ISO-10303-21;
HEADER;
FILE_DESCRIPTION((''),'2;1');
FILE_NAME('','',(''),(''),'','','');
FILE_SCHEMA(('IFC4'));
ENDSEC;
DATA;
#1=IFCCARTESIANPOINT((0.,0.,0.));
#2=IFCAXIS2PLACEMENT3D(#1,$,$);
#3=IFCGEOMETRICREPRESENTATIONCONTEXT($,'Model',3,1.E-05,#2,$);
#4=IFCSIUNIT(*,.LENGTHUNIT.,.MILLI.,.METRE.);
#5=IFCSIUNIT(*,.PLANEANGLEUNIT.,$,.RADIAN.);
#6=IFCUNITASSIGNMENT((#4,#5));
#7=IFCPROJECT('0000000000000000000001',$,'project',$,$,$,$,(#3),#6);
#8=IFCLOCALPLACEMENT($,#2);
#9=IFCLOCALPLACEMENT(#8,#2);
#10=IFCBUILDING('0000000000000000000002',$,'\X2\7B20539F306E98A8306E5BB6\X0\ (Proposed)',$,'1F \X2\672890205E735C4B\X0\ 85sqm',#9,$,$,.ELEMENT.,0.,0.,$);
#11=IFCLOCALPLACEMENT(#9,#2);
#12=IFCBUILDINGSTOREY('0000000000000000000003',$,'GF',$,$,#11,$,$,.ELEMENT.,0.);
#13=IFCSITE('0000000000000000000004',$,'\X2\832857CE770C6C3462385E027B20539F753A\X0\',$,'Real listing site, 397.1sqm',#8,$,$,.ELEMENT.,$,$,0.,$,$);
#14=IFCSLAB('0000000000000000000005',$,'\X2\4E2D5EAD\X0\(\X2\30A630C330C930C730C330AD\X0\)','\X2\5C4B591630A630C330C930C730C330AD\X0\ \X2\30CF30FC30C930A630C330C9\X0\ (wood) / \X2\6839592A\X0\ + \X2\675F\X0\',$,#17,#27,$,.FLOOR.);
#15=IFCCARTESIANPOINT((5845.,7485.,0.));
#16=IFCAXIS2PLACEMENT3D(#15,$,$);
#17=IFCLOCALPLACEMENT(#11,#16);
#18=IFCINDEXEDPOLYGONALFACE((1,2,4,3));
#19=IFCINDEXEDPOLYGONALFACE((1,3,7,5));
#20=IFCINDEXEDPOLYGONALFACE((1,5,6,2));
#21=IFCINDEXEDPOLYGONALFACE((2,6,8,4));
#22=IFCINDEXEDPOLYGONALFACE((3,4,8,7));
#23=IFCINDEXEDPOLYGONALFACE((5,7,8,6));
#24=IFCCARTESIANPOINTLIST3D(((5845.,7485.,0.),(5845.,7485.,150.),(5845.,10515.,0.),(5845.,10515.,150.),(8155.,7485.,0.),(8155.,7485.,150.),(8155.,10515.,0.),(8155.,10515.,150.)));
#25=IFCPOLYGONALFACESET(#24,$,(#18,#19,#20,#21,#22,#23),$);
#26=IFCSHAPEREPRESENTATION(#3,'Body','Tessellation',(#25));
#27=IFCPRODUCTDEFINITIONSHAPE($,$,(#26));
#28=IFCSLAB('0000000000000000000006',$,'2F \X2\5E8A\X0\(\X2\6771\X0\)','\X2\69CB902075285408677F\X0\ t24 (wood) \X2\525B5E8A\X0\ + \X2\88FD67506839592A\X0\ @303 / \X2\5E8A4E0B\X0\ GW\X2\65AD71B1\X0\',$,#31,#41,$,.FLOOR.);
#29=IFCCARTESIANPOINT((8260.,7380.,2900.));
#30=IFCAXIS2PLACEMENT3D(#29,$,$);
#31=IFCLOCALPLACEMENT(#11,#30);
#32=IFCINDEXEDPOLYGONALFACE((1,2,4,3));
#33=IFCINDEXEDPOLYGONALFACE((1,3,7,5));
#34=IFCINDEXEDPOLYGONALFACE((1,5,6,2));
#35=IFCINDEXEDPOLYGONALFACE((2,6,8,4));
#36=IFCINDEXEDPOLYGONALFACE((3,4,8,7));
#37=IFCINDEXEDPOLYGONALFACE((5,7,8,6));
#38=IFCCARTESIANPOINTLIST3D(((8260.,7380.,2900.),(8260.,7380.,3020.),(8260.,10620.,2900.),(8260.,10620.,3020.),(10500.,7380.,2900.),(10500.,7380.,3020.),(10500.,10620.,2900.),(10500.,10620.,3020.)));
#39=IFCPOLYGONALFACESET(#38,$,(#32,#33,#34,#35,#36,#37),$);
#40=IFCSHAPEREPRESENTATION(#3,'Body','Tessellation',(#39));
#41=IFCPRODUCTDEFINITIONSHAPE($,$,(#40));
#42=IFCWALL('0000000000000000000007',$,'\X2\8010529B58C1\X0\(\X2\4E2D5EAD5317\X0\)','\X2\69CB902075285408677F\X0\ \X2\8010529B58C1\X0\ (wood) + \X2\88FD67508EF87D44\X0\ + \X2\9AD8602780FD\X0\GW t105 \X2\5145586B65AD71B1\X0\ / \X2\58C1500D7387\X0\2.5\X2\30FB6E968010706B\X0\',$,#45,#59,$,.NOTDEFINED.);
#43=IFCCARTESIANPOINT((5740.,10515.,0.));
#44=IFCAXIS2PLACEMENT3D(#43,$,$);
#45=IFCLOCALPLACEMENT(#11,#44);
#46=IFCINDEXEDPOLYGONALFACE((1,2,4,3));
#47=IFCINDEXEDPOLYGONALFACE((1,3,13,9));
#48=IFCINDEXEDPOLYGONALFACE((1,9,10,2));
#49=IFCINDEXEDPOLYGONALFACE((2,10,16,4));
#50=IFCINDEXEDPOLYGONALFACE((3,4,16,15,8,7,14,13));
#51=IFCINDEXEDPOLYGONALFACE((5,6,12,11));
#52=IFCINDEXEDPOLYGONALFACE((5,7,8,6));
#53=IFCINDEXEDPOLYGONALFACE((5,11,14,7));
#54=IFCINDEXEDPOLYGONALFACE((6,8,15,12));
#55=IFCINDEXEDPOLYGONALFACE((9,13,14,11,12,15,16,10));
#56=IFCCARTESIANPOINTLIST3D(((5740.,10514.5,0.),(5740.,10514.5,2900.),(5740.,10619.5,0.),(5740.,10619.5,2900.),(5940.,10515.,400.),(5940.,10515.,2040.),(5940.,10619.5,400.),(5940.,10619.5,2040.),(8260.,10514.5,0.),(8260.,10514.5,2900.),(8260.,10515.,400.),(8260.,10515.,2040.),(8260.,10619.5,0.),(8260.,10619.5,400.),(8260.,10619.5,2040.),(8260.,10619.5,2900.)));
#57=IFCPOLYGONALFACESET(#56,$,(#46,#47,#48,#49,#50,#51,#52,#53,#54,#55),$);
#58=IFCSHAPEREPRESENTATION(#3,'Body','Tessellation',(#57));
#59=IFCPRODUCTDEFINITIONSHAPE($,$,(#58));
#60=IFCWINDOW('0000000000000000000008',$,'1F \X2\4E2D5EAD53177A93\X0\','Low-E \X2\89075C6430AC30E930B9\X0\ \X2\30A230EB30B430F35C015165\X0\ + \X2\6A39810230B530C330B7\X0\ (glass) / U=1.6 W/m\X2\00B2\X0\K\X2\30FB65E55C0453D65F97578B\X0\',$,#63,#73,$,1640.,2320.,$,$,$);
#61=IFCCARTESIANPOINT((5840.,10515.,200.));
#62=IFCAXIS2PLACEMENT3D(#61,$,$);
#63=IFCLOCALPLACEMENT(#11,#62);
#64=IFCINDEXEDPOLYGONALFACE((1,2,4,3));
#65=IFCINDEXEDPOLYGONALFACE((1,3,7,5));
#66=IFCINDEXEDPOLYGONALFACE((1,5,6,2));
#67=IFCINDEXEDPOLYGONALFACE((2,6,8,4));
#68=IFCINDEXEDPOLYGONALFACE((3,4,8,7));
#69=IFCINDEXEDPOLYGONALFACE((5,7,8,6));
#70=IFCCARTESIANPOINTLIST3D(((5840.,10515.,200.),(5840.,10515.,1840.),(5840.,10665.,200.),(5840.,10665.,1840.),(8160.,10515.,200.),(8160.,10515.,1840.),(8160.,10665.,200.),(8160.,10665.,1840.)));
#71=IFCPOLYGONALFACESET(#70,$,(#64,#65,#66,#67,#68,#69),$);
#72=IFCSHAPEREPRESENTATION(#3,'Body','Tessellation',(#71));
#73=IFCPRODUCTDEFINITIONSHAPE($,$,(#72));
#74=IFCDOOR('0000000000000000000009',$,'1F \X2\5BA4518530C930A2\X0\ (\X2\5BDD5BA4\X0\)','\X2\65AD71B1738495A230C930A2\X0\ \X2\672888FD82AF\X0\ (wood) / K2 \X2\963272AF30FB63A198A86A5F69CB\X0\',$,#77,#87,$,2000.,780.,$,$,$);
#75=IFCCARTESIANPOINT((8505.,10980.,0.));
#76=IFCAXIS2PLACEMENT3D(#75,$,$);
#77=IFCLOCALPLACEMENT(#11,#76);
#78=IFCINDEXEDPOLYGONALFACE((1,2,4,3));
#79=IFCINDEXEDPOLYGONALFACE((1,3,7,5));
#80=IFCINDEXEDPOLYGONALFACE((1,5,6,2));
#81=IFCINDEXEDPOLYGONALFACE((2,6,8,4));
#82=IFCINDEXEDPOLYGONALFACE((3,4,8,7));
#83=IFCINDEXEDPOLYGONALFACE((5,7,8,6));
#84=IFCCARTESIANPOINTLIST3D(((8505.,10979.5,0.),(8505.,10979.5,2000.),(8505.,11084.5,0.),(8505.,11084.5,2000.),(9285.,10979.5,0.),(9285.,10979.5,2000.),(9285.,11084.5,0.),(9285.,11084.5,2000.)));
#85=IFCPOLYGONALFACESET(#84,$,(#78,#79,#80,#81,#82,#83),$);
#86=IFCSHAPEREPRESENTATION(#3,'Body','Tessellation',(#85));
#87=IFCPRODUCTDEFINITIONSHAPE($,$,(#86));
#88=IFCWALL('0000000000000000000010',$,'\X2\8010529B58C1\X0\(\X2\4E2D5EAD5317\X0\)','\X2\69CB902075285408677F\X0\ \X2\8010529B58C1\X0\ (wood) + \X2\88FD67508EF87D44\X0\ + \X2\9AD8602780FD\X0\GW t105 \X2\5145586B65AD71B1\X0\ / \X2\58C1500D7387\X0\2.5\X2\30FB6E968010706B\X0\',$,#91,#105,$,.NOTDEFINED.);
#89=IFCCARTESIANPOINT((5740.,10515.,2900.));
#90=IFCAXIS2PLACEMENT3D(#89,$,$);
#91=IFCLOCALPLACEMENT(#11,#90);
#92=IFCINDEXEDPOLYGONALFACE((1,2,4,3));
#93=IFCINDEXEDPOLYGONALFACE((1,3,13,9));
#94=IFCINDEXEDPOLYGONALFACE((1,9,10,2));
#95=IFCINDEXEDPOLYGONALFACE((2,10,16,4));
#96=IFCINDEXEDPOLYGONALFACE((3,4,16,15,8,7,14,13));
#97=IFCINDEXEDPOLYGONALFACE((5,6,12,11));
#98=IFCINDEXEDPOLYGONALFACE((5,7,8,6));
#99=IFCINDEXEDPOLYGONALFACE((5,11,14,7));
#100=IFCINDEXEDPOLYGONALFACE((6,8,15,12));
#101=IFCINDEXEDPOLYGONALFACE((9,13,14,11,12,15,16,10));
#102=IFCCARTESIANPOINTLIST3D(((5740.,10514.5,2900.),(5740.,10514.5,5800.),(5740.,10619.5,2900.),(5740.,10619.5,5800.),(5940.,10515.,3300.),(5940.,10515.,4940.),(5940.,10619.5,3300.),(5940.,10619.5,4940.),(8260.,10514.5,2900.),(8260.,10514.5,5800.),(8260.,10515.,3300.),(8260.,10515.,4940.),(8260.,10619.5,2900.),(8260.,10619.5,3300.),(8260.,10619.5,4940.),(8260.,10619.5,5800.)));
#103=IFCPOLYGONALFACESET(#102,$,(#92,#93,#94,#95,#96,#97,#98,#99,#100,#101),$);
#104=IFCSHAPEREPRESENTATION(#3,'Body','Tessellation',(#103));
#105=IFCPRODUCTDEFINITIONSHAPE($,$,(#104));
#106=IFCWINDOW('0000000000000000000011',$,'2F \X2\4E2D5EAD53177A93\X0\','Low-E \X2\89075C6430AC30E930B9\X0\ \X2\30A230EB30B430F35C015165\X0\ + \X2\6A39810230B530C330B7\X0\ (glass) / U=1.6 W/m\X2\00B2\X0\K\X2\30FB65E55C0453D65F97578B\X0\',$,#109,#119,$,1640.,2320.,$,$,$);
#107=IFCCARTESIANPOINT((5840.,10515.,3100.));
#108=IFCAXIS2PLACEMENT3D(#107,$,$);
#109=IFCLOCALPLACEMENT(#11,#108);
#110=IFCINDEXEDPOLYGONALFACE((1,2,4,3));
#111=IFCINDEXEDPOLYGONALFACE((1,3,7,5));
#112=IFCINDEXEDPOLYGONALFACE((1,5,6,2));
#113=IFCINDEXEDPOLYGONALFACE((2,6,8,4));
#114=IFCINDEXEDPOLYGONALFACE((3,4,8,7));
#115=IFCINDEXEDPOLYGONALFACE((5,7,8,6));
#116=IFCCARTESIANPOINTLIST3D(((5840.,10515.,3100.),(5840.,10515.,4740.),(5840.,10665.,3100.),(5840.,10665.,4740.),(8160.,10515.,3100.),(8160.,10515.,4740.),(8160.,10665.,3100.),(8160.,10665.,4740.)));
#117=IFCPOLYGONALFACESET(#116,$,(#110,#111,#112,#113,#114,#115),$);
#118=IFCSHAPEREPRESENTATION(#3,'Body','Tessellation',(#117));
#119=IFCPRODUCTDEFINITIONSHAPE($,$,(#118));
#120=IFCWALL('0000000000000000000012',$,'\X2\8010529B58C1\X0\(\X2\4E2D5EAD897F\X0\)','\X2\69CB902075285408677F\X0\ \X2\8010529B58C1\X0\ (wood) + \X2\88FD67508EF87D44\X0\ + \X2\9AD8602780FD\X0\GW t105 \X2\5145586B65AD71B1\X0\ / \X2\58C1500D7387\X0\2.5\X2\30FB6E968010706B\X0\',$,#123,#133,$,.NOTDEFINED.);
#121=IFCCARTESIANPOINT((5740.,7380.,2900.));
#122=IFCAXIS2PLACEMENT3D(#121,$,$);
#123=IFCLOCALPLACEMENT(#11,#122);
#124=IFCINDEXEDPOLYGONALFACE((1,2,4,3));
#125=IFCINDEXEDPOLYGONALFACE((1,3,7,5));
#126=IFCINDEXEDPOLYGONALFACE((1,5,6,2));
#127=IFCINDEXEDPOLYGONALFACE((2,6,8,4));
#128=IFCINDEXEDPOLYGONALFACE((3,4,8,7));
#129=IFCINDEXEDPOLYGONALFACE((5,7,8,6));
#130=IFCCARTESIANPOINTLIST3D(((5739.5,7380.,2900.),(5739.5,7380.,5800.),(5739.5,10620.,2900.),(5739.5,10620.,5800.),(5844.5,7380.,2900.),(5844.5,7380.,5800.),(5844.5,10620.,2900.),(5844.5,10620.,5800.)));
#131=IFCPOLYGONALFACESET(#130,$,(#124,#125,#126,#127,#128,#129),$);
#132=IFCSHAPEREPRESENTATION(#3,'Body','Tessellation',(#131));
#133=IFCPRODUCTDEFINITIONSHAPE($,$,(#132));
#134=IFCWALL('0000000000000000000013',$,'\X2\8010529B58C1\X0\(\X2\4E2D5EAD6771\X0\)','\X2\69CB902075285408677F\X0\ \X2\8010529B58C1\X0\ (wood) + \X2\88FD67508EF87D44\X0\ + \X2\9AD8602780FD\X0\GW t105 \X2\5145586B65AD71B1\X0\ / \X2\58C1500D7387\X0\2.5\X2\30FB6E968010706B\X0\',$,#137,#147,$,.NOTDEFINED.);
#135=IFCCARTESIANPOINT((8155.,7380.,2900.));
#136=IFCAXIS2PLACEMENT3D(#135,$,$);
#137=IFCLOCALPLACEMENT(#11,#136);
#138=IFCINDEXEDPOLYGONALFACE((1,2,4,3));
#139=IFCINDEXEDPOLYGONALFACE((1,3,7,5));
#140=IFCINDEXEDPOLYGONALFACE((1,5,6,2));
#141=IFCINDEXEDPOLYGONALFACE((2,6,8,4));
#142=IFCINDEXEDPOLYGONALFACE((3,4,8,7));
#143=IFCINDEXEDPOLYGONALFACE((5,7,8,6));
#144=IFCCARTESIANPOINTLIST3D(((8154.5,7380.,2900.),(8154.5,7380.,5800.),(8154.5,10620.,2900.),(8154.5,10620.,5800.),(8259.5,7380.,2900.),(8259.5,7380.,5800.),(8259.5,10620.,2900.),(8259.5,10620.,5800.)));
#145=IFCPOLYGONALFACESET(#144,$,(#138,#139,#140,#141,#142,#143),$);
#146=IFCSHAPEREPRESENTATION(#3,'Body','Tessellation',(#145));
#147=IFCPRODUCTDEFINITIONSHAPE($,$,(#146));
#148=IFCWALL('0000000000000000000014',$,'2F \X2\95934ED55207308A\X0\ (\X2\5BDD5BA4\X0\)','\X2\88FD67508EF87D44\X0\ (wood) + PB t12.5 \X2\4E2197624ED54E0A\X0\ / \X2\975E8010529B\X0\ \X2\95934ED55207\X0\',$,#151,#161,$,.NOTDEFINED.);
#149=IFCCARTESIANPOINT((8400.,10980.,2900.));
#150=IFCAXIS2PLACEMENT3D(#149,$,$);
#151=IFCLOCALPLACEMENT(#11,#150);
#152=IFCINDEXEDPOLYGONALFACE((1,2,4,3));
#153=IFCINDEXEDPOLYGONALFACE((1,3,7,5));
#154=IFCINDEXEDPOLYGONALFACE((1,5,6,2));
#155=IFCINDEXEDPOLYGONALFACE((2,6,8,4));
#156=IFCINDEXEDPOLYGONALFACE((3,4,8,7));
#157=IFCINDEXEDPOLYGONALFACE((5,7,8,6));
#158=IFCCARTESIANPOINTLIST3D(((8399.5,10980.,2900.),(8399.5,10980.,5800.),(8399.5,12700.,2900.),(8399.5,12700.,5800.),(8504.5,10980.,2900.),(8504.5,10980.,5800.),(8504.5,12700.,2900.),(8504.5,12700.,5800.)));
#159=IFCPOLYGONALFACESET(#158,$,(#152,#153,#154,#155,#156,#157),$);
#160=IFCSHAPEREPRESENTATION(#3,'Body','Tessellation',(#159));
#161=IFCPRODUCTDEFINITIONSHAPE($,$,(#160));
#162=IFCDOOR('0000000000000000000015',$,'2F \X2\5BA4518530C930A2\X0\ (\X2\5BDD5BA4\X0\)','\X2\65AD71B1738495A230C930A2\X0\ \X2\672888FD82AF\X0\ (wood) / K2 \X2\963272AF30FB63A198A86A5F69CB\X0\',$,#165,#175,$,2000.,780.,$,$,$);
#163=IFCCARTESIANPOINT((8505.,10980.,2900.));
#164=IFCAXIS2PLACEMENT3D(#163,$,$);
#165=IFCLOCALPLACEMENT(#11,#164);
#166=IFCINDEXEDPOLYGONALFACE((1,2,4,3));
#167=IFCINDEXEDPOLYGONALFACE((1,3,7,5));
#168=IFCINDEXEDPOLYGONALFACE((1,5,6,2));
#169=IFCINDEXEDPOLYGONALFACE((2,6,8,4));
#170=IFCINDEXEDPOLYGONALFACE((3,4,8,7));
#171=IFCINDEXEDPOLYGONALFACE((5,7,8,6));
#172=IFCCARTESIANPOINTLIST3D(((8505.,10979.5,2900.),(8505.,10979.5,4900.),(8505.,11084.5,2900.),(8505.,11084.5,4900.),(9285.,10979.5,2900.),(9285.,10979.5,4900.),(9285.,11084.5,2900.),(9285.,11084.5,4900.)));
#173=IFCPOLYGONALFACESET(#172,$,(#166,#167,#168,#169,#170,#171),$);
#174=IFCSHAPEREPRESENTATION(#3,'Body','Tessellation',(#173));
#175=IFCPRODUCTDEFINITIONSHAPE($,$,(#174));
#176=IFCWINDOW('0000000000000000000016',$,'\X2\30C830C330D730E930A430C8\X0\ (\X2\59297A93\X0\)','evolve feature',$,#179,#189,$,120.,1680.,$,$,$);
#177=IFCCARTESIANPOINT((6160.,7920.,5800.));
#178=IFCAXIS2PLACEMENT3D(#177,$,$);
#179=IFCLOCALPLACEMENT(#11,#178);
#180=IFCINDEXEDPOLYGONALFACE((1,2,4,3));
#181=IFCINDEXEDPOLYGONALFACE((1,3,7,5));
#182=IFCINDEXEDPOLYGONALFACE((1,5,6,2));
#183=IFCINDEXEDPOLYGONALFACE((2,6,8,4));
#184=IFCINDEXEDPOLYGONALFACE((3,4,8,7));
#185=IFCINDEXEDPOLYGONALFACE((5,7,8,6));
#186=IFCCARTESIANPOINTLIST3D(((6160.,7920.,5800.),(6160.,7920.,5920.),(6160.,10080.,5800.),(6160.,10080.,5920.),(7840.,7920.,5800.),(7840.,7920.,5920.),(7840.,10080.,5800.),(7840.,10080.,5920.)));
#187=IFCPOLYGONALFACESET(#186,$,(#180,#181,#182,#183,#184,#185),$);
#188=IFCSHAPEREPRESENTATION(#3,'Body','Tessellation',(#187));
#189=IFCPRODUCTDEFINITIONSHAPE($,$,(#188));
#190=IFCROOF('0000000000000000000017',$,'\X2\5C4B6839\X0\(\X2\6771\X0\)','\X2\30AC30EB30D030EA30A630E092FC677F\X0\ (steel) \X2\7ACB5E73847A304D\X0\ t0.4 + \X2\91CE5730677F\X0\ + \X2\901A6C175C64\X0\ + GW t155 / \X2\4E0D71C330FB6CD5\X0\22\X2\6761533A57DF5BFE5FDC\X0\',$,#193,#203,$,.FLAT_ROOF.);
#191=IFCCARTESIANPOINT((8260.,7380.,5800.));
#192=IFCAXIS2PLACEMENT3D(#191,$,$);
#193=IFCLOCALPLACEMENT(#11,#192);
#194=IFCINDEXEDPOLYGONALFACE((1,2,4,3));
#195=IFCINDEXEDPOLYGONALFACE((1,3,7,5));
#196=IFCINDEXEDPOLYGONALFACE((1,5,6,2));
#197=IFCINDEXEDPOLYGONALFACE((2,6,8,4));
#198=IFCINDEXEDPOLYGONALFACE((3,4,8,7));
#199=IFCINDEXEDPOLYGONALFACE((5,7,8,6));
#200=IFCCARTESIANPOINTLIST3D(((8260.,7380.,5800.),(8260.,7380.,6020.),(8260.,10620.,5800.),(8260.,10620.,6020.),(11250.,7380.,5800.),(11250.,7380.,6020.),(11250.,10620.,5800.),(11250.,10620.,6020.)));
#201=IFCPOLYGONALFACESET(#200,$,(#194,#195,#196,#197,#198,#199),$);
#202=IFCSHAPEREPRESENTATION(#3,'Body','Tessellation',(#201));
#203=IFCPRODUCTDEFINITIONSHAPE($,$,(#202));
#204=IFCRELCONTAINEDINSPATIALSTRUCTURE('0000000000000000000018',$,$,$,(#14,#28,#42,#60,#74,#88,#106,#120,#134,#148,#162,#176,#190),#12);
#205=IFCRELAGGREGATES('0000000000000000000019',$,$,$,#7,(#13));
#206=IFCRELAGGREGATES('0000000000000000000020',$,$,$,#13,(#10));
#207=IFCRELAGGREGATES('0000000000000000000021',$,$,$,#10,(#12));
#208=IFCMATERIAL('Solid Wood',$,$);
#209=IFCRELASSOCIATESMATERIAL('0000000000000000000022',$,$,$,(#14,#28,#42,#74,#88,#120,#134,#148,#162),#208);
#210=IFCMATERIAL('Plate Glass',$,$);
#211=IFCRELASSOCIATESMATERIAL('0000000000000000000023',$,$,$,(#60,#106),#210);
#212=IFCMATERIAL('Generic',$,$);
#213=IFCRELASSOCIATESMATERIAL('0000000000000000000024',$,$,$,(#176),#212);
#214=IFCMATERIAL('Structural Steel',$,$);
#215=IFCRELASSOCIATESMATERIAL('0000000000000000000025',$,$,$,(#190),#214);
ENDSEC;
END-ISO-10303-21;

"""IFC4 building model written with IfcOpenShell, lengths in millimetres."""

from ifc_helpers import new_model, si_unit, frame, frame_2d, origin, place, context, project, spatial, rectangle, extrude, material, element, fill, save


model = new_model("IFC4")

# Units and contexts
model_context = context("Model", 3, precision=1e-05, world=origin())
ifc_project = project(units=[si_unit("LENGTHUNIT", "METRE", prefix="MILLI"), si_unit("PLANEANGLEUNIT", "RADIAN")], contexts=[model_context])

# Site, building, storey
site_placement = place(None, origin())
site = spatial("IfcSite", under=ifc_project, at=site_placement, Name="茨城県水戸市笠原町", ObjectType="Real listing site, 397.1sqm", CompositionType="ELEMENT", RefElevation=0.0)
building_placement = place(site_placement, origin())
building = spatial("IfcBuilding", under=site, at=building_placement, Name="笠原の風の家 (Proposed)", ObjectType="1F 木造平屋 85sqm", CompositionType="ELEMENT", ElevationOfRefHeight=0.0, ElevationOfTerrain=0.0)
storey_placement = place(building_placement, origin())
storey = spatial("IfcBuildingStorey", under=building, at=storey_placement, Name="GF", CompositionType="ELEMENT", Elevation=0.0)

# Slabs
ifc_material_1 = material(Name="Solid Wood")
slab_1_placement = place(storey_placement, frame((5845.0, 7485.0, 0.0)))
element("IfcSlab", 1, at=slab_1_placement, inside=storey, material=ifc_material_1, Name="中庭(ウッドデッキ)", Description="屋外ウッドデッキ ハードウッド (wood) / 根太 + 束", PredefinedType="FLOOR", context=model_context, shape_type="SweptSolid", body=[
    extrude(rectangle(XDim=2310.0, YDim=3030.0, at=frame_2d((1155.0, 1515.0))), frame((5845.0, 7485.0, 0.0)), (0.0, 0.0, 1.0), 150.0),
])
slab_2_placement = place(storey_placement, frame((8260.0, 7380.0, 2900.0)))
element("IfcSlab", 2, at=slab_2_placement, inside=storey, material=ifc_material_1, Name="2F 床(東)", Description="構造用合板 t24 (wood) 剛床 + 製材根太 @303 / 床下 GW断熱", PredefinedType="FLOOR", context=model_context, shape_type="SweptSolid", body=[
    extrude(rectangle(XDim=2240.0, YDim=3240.0, at=frame_2d((1120.0, 1620.0))), frame((8260.0, 7380.0, 2900.0)), (0.0, 0.0, 1.0), 120.0),
])

# Wall, opening, window
wall_1_placement = place(storey_placement, frame((5740.0, 10515.0, 0.0)))
wall_1 = element("IfcWall", 3, at=wall_1_placement, inside=storey, material=ifc_material_1, Name="耐力壁(中庭北)", Description="構造用合板 耐力壁 (wood) + 製材軸組 + 高性能GW t105 充填断熱 / 壁倍率2.5・準耐火", PredefinedType="NOTDEFINED", context=model_context, shape_type="SweptSolid", body=[
    extrude(rectangle(XDim=2520.0, YDim=105.0, at=frame_2d((1260.0, 52.0))), frame((5740.0, 10515.0, 0.0)), (0.0, 0.0, 1.0), 2900.0),
])
opening_1_placement = place(storey_placement, frame((5840.0, 10515.0, 200.0)))
opening_1 = element("IfcOpeningElement", 4, at=opening_1_placement, cuts=wall_1, PredefinedType="NOTDEFINED", context=model_context, shape_type="SweptSolid", body=[
    extrude(rectangle(XDim=2320.0, YDim=150.0, at=frame_2d((1160.0, 75.0))), frame((5840.0, 10515.0, 200.0)), (0.0, 0.0, 1.0), 1640.0),
])
ifc_material_2 = material(Name="Plate Glass")
window_1_placement = place(storey_placement, frame((5840.0, 10515.0, 200.0)))
window_1 = element("IfcWindow", 5, at=window_1_placement, inside=storey, material=ifc_material_2, Name="1F 中庭北窓", Description="Low-E 複層ガラス アルゴン封入 + 樹脂サッシ (glass) / U=1.6 W/m²K・日射取得型", OverallHeight=1640.0, OverallWidth=2320.0, context=model_context, shape_type="SweptSolid", body=[
    extrude(rectangle(XDim=2320.0, YDim=150.0, at=frame_2d((1160.0, 75.0))), frame((5840.0, 10515.0, 200.0)), (0.0, 0.0, 1.0), 1640.0),
])
fill(opening_1, window_1)

# Door
door_1_placement = place(storey_placement, frame((8505.0, 10980.0, 0.0)))
element("IfcDoor", 6, at=door_1_placement, inside=storey, material=ifc_material_1, Name="1F 室内ドア (寝室)", Description="断熱玄関ドア 木製芯 (wood) / K2 防犯・採風機構", OverallHeight=2000.0, OverallWidth=780.0, context=model_context, shape_type="SweptSolid", body=[
    extrude(rectangle(XDim=780.0, YDim=105.0, at=frame_2d((390.0, 52.0))), frame((8505.0, 10980.0, 0.0)), (0.0, 0.0, 1.0), 2000.0),
])

# Wall, opening, window
wall_2_placement = place(storey_placement, frame((5740.0, 10515.0, 2900.0)))
wall_2 = element("IfcWall", 7, at=wall_2_placement, inside=storey, material=ifc_material_1, Name="耐力壁(中庭北)", Description="構造用合板 耐力壁 (wood) + 製材軸組 + 高性能GW t105 充填断熱 / 壁倍率2.5・準耐火", PredefinedType="NOTDEFINED", context=model_context, shape_type="SweptSolid", body=[
    extrude(rectangle(XDim=2520.0, YDim=105.0, at=frame_2d((1260.0, 52.0))), frame((5740.0, 10515.0, 2900.0)), (0.0, 0.0, 1.0), 2900.0),
])
opening_2_placement = place(storey_placement, frame((5840.0, 10515.0, 3100.0)))
opening_2 = element("IfcOpeningElement", 8, at=opening_2_placement, cuts=wall_2, PredefinedType="NOTDEFINED", context=model_context, shape_type="SweptSolid", body=[
    extrude(rectangle(XDim=2320.0, YDim=150.0, at=frame_2d((1160.0, 75.0))), frame((5840.0, 10515.0, 3100.0)), (0.0, 0.0, 1.0), 1640.0),
])
window_2_placement = place(storey_placement, frame((5840.0, 10515.0, 3100.0)))
window_2 = element("IfcWindow", 9, at=window_2_placement, inside=storey, material=ifc_material_2, Name="2F 中庭北窓", Description="Low-E 複層ガラス アルゴン封入 + 樹脂サッシ (glass) / U=1.6 W/m²K・日射取得型", OverallHeight=1640.0, OverallWidth=2320.0, context=model_context, shape_type="SweptSolid", body=[
    extrude(rectangle(XDim=2320.0, YDim=150.0, at=frame_2d((1160.0, 75.0))), frame((5840.0, 10515.0, 3100.0)), (0.0, 0.0, 1.0), 1640.0),
])
fill(opening_2, window_2)

# Walls
wall_3_placement = place(storey_placement, frame((5740.0, 7380.0, 2900.0)))
element("IfcWall", 10, at=wall_3_placement, inside=storey, material=ifc_material_1, Name="耐力壁(中庭西)", Description="構造用合板 耐力壁 (wood) + 製材軸組 + 高性能GW t105 充填断熱 / 壁倍率2.5・準耐火", PredefinedType="NOTDEFINED", context=model_context, shape_type="SweptSolid", body=[
    extrude(rectangle(XDim=105.0, YDim=3240.0, at=frame_2d((52.0, 1620.0))), frame((5740.0, 7380.0, 2900.0)), (0.0, 0.0, 1.0), 2900.0),
])
wall_4_placement = place(storey_placement, frame((8155.0, 7380.0, 2900.0)))
element("IfcWall", 11, at=wall_4_placement, inside=storey, material=ifc_material_1, Name="耐力壁(中庭東)", Description="構造用合板 耐力壁 (wood) + 製材軸組 + 高性能GW t105 充填断熱 / 壁倍率2.5・準耐火", PredefinedType="NOTDEFINED", context=model_context, shape_type="SweptSolid", body=[
    extrude(rectangle(XDim=105.0, YDim=3240.0, at=frame_2d((52.0, 1620.0))), frame((8155.0, 7380.0, 2900.0)), (0.0, 0.0, 1.0), 2900.0),
])
wall_5_placement = place(storey_placement, frame((8400.0, 10980.0, 2900.0)))
element("IfcWall", 12, at=wall_5_placement, inside=storey, material=ifc_material_1, Name="2F 間仕切り (寝室)", Description="製材軸組 (wood) + PB t12.5 両面仕上 / 非耐力 間仕切", PredefinedType="NOTDEFINED", context=model_context, shape_type="SweptSolid", body=[
    extrude(rectangle(XDim=105.0, YDim=1720.0, at=frame_2d((52.0, 860.0))), frame((8400.0, 10980.0, 2900.0)), (0.0, 0.0, 1.0), 2900.0),
])

# Door
door_2_placement = place(storey_placement, frame((8505.0, 10980.0, 2900.0)))
element("IfcDoor", 13, at=door_2_placement, inside=storey, material=ifc_material_1, Name="2F 室内ドア (寝室)", Description="断熱玄関ドア 木製芯 (wood) / K2 防犯・採風機構", OverallHeight=2000.0, OverallWidth=780.0, context=model_context, shape_type="SweptSolid", body=[
    extrude(rectangle(XDim=780.0, YDim=105.0, at=frame_2d((390.0, 52.0))), frame((8505.0, 10980.0, 2900.0)), (0.0, 0.0, 1.0), 2000.0),
])

# Window
ifc_material_3 = material(Name="Generic")
window_3_placement = place(storey_placement, frame((6160.0, 7920.0, 5800.0)))
element("IfcWindow", 14, at=window_3_placement, inside=storey, material=ifc_material_3, Name="トップライト (天窓)", Description="evolve feature", OverallHeight=120.0, OverallWidth=1680.0, context=model_context, shape_type="SweptSolid", body=[
    extrude(rectangle(XDim=1680.0, YDim=2160.0, at=frame_2d((840.0, 1080.0))), frame((6160.0, 7920.0, 5800.0)), (0.0, 0.0, 1.0), 120.0),
])

# Roof
ifc_material_4 = material(Name="Structural Steel")
roof_placement = place(storey_placement, frame((8260.0, 7380.0, 5800.0)))
element("IfcRoof", 15, at=roof_placement, inside=storey, material=ifc_material_4, Name="屋根(東)", Description="ガルバリウム鋼板 (steel) 立平葺き t0.4 + 野地板 + 通気層 + GW t155 / 不燃・法22条区域対応", PredefinedType="FLAT_ROOF", context=model_context, shape_type="SweptSolid", body=[
    extrude(rectangle(XDim=2990.0, YDim=3240.0, at=frame_2d((1495.0, 1620.0))), frame((8260.0, 7380.0, 5800.0)), (0.0, 0.0, 1.0), 220.0),
])

save(model, "model.ifc")
